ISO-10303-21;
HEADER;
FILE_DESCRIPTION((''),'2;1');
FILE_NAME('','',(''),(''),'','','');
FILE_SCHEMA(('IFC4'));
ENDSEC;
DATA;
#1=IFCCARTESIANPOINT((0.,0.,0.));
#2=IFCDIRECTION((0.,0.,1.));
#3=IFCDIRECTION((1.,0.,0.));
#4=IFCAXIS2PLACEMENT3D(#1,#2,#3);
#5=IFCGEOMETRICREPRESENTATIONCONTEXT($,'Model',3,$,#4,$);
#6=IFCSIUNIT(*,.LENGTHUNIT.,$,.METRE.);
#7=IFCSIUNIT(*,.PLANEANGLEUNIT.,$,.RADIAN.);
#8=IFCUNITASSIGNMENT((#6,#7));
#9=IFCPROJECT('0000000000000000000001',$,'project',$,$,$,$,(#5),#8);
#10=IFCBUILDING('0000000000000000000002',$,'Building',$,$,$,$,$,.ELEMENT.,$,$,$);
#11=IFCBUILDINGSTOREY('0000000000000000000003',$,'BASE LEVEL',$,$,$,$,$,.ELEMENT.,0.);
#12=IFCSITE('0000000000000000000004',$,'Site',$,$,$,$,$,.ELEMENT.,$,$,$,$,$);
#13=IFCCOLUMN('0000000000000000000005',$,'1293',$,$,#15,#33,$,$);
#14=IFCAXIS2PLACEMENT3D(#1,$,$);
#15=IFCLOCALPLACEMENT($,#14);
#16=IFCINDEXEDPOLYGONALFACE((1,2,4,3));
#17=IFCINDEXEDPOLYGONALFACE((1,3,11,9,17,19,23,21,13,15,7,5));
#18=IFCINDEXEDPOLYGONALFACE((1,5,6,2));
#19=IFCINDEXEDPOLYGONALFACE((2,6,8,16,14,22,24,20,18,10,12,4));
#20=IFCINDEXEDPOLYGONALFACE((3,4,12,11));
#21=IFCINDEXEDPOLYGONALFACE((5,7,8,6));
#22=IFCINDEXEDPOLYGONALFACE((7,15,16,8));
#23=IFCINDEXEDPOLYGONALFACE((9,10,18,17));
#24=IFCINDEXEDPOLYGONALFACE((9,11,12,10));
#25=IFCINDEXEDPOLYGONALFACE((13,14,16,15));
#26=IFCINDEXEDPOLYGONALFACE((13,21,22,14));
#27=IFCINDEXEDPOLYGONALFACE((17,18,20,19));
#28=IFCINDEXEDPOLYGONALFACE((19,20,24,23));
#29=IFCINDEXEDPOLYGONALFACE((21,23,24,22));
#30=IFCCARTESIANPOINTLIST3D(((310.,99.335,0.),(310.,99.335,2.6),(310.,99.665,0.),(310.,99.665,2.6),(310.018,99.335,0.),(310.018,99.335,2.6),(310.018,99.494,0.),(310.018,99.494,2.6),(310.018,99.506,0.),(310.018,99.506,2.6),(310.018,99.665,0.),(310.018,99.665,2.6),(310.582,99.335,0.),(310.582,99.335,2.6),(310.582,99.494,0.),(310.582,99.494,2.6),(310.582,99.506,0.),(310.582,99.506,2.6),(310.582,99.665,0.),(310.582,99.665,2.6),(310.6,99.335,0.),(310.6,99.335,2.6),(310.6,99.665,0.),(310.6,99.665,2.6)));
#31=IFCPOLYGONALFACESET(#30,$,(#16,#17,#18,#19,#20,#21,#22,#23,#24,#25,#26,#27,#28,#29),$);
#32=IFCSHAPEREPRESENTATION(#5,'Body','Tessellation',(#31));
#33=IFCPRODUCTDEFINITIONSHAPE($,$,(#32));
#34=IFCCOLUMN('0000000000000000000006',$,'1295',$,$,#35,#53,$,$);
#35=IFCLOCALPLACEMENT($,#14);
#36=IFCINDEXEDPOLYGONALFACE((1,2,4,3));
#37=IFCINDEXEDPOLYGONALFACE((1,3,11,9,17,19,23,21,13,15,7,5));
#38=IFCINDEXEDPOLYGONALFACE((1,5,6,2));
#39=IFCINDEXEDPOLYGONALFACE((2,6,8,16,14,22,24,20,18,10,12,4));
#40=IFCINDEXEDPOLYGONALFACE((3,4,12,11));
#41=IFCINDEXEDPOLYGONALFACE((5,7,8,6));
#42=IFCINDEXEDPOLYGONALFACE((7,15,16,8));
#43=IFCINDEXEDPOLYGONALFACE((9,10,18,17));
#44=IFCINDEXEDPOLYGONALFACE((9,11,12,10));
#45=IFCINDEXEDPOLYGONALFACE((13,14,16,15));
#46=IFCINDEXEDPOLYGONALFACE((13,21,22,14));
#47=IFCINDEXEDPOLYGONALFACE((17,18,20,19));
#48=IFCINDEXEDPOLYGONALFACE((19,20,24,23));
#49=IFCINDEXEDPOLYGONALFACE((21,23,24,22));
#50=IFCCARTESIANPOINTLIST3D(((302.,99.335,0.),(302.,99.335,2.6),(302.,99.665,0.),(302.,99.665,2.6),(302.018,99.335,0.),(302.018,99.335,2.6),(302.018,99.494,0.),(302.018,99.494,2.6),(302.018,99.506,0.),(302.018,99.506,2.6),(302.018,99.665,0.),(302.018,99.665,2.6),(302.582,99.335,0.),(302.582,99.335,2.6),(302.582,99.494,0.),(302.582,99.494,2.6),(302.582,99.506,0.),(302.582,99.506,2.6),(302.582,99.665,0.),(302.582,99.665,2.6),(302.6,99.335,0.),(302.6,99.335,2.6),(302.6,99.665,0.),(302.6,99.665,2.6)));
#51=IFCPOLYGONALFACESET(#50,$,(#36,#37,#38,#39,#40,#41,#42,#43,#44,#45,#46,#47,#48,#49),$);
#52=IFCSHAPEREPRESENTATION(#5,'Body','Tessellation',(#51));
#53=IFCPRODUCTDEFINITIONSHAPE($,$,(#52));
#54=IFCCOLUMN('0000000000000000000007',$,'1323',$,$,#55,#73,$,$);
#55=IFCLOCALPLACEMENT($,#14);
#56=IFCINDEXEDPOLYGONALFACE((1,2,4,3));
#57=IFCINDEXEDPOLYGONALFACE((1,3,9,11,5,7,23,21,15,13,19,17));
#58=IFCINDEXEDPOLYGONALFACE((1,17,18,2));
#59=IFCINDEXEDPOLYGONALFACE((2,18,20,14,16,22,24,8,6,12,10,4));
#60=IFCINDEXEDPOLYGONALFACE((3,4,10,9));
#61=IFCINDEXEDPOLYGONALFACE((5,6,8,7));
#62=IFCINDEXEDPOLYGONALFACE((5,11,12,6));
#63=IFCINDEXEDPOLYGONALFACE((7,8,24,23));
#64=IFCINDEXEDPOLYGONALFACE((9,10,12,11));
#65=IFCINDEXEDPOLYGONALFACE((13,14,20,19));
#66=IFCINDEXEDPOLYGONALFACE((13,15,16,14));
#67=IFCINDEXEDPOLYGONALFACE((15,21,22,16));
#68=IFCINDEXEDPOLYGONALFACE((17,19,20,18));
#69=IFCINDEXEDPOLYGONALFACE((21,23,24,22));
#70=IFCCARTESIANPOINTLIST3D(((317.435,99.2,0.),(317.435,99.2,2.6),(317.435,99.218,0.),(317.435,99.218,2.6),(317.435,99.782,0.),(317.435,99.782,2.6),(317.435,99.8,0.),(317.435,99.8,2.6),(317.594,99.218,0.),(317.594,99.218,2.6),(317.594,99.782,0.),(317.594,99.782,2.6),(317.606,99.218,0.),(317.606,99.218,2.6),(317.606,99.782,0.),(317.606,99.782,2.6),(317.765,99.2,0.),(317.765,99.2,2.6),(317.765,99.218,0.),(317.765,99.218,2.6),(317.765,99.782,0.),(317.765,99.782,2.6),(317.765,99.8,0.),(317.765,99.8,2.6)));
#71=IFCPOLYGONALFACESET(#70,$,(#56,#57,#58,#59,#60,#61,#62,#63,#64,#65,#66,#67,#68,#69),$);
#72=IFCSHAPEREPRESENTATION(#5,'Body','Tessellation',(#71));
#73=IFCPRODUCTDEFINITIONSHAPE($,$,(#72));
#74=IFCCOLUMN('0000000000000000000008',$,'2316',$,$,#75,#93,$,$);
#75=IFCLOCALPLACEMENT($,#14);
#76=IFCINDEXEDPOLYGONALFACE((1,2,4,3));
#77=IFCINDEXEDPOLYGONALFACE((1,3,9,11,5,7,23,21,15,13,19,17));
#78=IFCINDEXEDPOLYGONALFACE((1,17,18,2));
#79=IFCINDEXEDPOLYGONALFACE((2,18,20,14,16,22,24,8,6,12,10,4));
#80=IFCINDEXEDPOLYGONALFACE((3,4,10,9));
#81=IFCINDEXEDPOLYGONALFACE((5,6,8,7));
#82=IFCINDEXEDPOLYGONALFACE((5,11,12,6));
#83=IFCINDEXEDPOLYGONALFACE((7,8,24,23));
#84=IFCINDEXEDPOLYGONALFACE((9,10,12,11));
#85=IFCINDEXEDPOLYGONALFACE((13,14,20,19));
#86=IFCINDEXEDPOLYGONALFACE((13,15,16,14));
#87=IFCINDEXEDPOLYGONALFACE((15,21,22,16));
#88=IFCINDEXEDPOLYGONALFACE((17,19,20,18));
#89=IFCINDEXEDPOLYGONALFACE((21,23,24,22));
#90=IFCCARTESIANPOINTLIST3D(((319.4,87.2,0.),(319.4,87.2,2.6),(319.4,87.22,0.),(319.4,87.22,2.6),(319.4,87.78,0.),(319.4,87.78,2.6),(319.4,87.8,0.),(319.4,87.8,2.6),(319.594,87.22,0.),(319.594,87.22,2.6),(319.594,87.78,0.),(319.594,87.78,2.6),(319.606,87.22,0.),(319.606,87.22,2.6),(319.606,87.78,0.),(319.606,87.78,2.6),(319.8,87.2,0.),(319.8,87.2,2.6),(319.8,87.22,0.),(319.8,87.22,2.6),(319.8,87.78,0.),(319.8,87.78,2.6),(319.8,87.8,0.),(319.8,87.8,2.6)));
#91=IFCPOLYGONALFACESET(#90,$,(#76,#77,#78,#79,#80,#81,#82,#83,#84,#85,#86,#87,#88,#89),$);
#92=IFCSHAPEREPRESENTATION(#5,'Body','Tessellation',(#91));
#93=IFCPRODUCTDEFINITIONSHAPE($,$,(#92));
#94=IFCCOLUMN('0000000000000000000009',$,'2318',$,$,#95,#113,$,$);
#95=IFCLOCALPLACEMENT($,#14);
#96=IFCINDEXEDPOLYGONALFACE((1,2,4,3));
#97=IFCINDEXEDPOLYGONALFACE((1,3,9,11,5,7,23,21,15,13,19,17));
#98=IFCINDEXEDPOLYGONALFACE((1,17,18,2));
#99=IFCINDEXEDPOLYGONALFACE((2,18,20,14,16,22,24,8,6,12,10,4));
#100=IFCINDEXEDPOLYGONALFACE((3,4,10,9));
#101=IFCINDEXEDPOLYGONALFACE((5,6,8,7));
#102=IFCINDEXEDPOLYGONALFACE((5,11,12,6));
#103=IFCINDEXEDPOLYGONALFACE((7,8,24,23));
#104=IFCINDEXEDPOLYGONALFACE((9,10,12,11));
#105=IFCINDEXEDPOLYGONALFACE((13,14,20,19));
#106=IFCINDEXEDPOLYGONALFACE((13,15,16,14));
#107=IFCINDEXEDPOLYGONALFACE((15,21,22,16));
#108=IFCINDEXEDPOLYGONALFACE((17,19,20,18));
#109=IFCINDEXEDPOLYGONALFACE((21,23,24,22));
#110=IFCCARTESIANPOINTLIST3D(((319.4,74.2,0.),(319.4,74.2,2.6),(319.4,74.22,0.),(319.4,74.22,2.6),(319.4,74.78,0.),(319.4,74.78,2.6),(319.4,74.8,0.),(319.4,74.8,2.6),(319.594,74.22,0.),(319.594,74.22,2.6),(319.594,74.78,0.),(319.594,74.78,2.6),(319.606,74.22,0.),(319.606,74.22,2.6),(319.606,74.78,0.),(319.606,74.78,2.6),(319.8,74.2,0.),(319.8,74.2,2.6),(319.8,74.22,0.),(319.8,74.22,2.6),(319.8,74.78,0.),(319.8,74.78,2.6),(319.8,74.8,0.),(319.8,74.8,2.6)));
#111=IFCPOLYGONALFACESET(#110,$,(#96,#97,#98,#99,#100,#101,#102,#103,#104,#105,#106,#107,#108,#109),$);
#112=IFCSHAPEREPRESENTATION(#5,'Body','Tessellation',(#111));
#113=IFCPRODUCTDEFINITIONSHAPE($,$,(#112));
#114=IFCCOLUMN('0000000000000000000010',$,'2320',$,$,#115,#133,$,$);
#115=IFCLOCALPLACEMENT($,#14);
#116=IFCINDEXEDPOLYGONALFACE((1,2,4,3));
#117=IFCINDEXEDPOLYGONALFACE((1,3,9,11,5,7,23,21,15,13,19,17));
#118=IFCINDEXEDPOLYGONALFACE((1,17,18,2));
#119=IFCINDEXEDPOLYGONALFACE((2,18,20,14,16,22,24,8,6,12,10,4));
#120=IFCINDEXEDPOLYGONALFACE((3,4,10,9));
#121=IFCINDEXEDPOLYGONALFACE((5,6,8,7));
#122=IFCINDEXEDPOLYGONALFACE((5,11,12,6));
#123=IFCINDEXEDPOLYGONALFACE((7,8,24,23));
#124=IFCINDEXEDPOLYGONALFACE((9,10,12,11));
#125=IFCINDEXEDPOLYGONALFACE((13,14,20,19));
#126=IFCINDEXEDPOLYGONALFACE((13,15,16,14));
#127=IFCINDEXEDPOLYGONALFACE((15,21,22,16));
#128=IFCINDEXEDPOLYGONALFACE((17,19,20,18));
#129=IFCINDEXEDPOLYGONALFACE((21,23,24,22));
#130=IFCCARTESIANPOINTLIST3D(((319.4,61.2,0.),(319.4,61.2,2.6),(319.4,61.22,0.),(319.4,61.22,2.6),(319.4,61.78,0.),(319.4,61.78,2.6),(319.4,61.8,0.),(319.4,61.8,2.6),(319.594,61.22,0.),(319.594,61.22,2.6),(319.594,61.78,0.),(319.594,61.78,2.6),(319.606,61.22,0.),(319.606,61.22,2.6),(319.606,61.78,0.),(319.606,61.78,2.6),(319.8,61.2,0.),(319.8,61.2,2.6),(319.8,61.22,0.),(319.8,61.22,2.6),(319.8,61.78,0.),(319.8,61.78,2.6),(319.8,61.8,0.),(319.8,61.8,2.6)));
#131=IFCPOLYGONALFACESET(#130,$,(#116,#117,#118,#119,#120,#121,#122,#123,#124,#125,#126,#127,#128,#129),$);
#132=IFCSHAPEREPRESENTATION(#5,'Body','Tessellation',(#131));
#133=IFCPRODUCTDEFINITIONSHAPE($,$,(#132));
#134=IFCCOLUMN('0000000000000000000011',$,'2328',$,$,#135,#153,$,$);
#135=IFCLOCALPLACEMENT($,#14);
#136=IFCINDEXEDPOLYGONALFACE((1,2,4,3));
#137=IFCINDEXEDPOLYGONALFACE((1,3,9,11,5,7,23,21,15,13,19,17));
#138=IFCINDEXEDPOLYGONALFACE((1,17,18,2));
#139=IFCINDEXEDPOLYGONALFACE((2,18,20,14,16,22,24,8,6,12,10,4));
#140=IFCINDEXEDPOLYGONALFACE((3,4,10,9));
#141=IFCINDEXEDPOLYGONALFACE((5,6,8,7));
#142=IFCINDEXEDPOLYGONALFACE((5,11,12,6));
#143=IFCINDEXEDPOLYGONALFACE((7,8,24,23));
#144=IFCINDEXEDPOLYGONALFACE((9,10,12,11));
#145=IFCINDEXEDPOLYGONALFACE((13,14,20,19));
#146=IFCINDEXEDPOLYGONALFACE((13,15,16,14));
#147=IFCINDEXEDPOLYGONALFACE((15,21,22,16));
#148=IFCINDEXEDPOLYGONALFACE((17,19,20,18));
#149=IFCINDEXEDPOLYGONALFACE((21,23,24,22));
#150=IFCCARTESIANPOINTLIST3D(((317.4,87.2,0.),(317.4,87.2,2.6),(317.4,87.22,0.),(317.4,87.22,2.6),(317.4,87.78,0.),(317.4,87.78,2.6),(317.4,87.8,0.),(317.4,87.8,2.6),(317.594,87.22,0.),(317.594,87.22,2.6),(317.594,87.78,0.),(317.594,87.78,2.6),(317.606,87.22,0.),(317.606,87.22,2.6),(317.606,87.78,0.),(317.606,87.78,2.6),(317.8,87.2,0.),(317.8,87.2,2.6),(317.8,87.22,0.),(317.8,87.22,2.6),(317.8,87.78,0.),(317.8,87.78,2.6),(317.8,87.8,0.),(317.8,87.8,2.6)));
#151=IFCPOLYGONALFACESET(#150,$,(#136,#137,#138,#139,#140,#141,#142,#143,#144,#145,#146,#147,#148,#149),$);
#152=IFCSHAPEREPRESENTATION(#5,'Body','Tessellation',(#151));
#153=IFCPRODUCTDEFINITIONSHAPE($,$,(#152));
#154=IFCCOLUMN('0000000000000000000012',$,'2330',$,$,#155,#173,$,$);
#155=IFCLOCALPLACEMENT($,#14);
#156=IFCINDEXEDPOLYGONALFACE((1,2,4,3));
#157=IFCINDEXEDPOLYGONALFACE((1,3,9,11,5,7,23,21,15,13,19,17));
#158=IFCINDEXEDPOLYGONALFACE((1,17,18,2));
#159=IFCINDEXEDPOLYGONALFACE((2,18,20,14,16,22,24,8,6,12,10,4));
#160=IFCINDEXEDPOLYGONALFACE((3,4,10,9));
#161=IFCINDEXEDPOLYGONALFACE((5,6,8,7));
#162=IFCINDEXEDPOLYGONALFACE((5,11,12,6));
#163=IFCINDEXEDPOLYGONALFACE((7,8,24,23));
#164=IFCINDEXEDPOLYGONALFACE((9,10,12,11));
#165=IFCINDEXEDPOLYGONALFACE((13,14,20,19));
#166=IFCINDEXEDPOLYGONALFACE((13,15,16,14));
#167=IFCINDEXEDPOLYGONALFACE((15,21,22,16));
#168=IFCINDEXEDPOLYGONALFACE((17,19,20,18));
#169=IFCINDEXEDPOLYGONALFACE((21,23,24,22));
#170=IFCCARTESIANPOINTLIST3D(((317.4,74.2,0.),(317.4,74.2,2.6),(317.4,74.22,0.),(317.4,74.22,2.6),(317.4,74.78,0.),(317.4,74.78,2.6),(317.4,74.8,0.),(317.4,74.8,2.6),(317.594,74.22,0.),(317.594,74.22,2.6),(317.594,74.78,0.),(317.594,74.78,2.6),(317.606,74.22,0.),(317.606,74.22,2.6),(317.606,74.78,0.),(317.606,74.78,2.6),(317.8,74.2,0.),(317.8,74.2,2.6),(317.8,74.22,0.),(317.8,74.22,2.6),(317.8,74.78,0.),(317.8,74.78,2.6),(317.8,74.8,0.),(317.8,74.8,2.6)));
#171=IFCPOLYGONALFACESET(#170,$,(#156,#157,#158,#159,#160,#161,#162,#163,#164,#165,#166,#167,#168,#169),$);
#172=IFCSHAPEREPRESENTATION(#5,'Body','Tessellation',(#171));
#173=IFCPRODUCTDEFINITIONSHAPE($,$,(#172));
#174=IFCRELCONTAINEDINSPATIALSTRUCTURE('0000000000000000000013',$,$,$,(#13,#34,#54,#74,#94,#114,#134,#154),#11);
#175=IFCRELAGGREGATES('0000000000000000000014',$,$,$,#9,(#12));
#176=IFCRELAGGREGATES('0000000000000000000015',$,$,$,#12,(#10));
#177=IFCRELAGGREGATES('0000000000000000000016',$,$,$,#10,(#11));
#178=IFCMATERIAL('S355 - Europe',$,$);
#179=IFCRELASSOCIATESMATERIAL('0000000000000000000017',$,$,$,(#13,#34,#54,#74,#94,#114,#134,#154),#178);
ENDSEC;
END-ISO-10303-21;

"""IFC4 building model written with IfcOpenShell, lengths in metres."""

from ifc_helpers import new_model, si_unit, frame, origin_with_axes, origin_2d_with_axis, place, context, project, spatial, i_section, extrude, material, material_profile, profile_set, profile_usage, element, save


model = new_model("IFC4")

# Units and contexts
model_context = context("Model", 3, world=origin_with_axes())
ifc_project = project(units=[si_unit("LENGTHUNIT", "METRE"), si_unit("PLANEANGLEUNIT", "RADIAN")], contexts=[model_context])

# Site, building, storey
site = spatial("IfcSite", under=ifc_project, Name="Site", CompositionType="ELEMENT")
building = spatial("IfcBuilding", under=site, Name="Building", CompositionType="ELEMENT")
storey = spatial("IfcBuildingStorey", under=building, Name="BASE LEVEL", CompositionType="ELEMENT", Elevation=0.0)

# Columns
ifc_material = material(Name="S355 - Europe")
ifc_material_profile_1 = material_profile(ifc_material, i_section(OverallWidth=0.33, OverallDepth=0.6, WebThickness=0.012, FlangeThickness=0.018, at=origin_2d_with_axis()))
ifc_profile_set_1 = profile_set([ifc_material_profile_1])
ifc_profile_usage_1 = profile_usage(ifc_profile_set_1, cardinal=10)
column_1_placement = place(None, frame((310.3, 99.5, 0.0), z_axis=(0.0, 0.0, 1.0), x_axis=(0.0, -1.0, 0.0)))
element("IfcColumn", 1, at=column_1_placement, inside=storey, material=ifc_profile_usage_1, Name="1293", context=model_context, shape_type="SweptSolid", body=[
    extrude(i_section(OverallWidth=0.33, OverallDepth=0.6, WebThickness=0.012, FlangeThickness=0.018, at=origin_2d_with_axis()), origin_with_axes(), (0.0, 0.0, 1.0), 2.6),
])
ifc_material_profile_2 = material_profile(ifc_material, i_section(OverallWidth=0.33, OverallDepth=0.6, WebThickness=0.012, FlangeThickness=0.018, at=origin_2d_with_axis()))
ifc_profile_set_2 = profile_set([ifc_material_profile_2])
ifc_profile_usage_2 = profile_usage(ifc_profile_set_2, cardinal=10)
column_2_placement = place(None, frame((302.3, 99.5, 0.0), z_axis=(0.0, 0.0, 1.0), x_axis=(0.0, -1.0, 0.0)))
element("IfcColumn", 2, at=column_2_placement, inside=storey, material=ifc_profile_usage_2, Name="1295", context=model_context, shape_type="SweptSolid", body=[
    extrude(i_section(OverallWidth=0.33, OverallDepth=0.6, WebThickness=0.012, FlangeThickness=0.018, at=origin_2d_with_axis()), origin_with_axes(), (0.0, 0.0, 1.0), 2.6),
])
ifc_material_profile_3 = material_profile(ifc_material, i_section(OverallWidth=0.33, OverallDepth=0.6, WebThickness=0.012, FlangeThickness=0.018, at=origin_2d_with_axis()))
ifc_profile_set_3 = profile_set([ifc_material_profile_3])
ifc_profile_usage_3 = profile_usage(ifc_profile_set_3, cardinal=10)
column_3_placement = place(None, frame((317.6, 99.5, 0.0), z_axis=(0.0, 0.0, 1.0), x_axis=(1.0, 0.0, 0.0)))
element("IfcColumn", 3, at=column_3_placement, inside=storey, material=ifc_profile_usage_3, Name="1323", context=model_context, shape_type="SweptSolid", body=[
    extrude(i_section(OverallWidth=0.33, OverallDepth=0.6, WebThickness=0.012, FlangeThickness=0.018, at=origin_2d_with_axis()), origin_with_axes(), (0.0, 0.0, 1.0), 2.6),
])
ifc_material_profile_4 = material_profile(ifc_material, i_section(OverallWidth=0.4, OverallDepth=0.6, WebThickness=0.012, FlangeThickness=0.02, at=origin_2d_with_axis()))
ifc_profile_set_4 = profile_set([ifc_material_profile_4])
ifc_profile_usage_4 = profile_usage(ifc_profile_set_4, cardinal=10)
column_4_placement = place(None, frame((319.6, 87.5, 0.0), z_axis=(0.0, 0.0, 1.0), x_axis=(1.0, 0.0, 0.0)))
element("IfcColumn", 4, at=column_4_placement, inside=storey, material=ifc_profile_usage_4, Name="2316", context=model_context, shape_type="SweptSolid", body=[
    extrude(i_section(OverallWidth=0.4, OverallDepth=0.6, WebThickness=0.012, FlangeThickness=0.02, at=origin_2d_with_axis()), origin_with_axes(), (0.0, 0.0, 1.0), 2.6),
])
ifc_material_profile_5 = material_profile(ifc_material, i_section(OverallWidth=0.4, OverallDepth=0.6, WebThickness=0.012, FlangeThickness=0.02, at=origin_2d_with_axis()))
ifc_profile_set_5 = profile_set([ifc_material_profile_5])
ifc_profile_usage_5 = profile_usage(ifc_profile_set_5, cardinal=10)
column_5_placement = place(None, frame((319.6, 74.5, 0.0), z_axis=(0.0, 0.0, 1.0), x_axis=(1.0, 0.0, 0.0)))
element("IfcColumn", 5, at=column_5_placement, inside=storey, material=ifc_profile_usage_5, Name="2318", context=model_context, shape_type="SweptSolid", body=[
    extrude(i_section(OverallWidth=0.4, OverallDepth=0.6, WebThickness=0.012, FlangeThickness=0.02, at=origin_2d_with_axis()), origin_with_axes(), (0.0, 0.0, 1.0), 2.6),
])
ifc_material_profile_6 = material_profile(ifc_material, i_section(OverallWidth=0.4, OverallDepth=0.6, WebThickness=0.012, FlangeThickness=0.02, at=origin_2d_with_axis()))
ifc_profile_set_6 = profile_set([ifc_material_profile_6])
ifc_profile_usage_6 = profile_usage(ifc_profile_set_6, cardinal=10)
column_6_placement = place(None, frame((319.6, 61.5, 0.0), z_axis=(0.0, 0.0, 1.0), x_axis=(1.0, 0.0, 0.0)))
element("IfcColumn", 6, at=column_6_placement, inside=storey, material=ifc_profile_usage_6, Name="2320", context=model_context, shape_type="SweptSolid", body=[
    extrude(i_section(OverallWidth=0.4, OverallDepth=0.6, WebThickness=0.012, FlangeThickness=0.02, at=origin_2d_with_axis()), origin_with_axes(), (0.0, 0.0, 1.0), 2.6),
])
ifc_material_profile_7 = material_profile(ifc_material, i_section(OverallWidth=0.4, OverallDepth=0.6, WebThickness=0.012, FlangeThickness=0.02, at=origin_2d_with_axis()))
ifc_profile_set_7 = profile_set([ifc_material_profile_7])
ifc_profile_usage_7 = profile_usage(ifc_profile_set_7, cardinal=10)
column_7_placement = place(None, frame((317.6, 87.5, 0.0), z_axis=(0.0, 0.0, 1.0), x_axis=(1.0, 0.0, 0.0)))
element("IfcColumn", 7, at=column_7_placement, inside=storey, material=ifc_profile_usage_7, Name="2328", context=model_context, shape_type="SweptSolid", body=[
    extrude(i_section(OverallWidth=0.4, OverallDepth=0.6, WebThickness=0.012, FlangeThickness=0.02, at=origin_2d_with_axis()), origin_with_axes(), (0.0, 0.0, 1.0), 2.6),
])
ifc_material_profile_8 = material_profile(ifc_material, i_section(OverallWidth=0.4, OverallDepth=0.6, WebThickness=0.012, FlangeThickness=0.02, at=origin_2d_with_axis()))
ifc_profile_set_8 = profile_set([ifc_material_profile_8])
ifc_profile_usage_8 = profile_usage(ifc_profile_set_8, cardinal=10)
column_8_placement = place(None, frame((317.6, 74.5, 0.0), z_axis=(0.0, 0.0, 1.0), x_axis=(1.0, 0.0, 0.0)))
element("IfcColumn", 8, at=column_8_placement, inside=storey, material=ifc_profile_usage_8, Name="2330", context=model_context, shape_type="SweptSolid", body=[
    extrude(i_section(OverallWidth=0.4, OverallDepth=0.6, WebThickness=0.012, FlangeThickness=0.02, at=origin_2d_with_axis()), origin_with_axes(), (0.0, 0.0, 1.0), 2.6),
])

save(model, "model.ifc")
